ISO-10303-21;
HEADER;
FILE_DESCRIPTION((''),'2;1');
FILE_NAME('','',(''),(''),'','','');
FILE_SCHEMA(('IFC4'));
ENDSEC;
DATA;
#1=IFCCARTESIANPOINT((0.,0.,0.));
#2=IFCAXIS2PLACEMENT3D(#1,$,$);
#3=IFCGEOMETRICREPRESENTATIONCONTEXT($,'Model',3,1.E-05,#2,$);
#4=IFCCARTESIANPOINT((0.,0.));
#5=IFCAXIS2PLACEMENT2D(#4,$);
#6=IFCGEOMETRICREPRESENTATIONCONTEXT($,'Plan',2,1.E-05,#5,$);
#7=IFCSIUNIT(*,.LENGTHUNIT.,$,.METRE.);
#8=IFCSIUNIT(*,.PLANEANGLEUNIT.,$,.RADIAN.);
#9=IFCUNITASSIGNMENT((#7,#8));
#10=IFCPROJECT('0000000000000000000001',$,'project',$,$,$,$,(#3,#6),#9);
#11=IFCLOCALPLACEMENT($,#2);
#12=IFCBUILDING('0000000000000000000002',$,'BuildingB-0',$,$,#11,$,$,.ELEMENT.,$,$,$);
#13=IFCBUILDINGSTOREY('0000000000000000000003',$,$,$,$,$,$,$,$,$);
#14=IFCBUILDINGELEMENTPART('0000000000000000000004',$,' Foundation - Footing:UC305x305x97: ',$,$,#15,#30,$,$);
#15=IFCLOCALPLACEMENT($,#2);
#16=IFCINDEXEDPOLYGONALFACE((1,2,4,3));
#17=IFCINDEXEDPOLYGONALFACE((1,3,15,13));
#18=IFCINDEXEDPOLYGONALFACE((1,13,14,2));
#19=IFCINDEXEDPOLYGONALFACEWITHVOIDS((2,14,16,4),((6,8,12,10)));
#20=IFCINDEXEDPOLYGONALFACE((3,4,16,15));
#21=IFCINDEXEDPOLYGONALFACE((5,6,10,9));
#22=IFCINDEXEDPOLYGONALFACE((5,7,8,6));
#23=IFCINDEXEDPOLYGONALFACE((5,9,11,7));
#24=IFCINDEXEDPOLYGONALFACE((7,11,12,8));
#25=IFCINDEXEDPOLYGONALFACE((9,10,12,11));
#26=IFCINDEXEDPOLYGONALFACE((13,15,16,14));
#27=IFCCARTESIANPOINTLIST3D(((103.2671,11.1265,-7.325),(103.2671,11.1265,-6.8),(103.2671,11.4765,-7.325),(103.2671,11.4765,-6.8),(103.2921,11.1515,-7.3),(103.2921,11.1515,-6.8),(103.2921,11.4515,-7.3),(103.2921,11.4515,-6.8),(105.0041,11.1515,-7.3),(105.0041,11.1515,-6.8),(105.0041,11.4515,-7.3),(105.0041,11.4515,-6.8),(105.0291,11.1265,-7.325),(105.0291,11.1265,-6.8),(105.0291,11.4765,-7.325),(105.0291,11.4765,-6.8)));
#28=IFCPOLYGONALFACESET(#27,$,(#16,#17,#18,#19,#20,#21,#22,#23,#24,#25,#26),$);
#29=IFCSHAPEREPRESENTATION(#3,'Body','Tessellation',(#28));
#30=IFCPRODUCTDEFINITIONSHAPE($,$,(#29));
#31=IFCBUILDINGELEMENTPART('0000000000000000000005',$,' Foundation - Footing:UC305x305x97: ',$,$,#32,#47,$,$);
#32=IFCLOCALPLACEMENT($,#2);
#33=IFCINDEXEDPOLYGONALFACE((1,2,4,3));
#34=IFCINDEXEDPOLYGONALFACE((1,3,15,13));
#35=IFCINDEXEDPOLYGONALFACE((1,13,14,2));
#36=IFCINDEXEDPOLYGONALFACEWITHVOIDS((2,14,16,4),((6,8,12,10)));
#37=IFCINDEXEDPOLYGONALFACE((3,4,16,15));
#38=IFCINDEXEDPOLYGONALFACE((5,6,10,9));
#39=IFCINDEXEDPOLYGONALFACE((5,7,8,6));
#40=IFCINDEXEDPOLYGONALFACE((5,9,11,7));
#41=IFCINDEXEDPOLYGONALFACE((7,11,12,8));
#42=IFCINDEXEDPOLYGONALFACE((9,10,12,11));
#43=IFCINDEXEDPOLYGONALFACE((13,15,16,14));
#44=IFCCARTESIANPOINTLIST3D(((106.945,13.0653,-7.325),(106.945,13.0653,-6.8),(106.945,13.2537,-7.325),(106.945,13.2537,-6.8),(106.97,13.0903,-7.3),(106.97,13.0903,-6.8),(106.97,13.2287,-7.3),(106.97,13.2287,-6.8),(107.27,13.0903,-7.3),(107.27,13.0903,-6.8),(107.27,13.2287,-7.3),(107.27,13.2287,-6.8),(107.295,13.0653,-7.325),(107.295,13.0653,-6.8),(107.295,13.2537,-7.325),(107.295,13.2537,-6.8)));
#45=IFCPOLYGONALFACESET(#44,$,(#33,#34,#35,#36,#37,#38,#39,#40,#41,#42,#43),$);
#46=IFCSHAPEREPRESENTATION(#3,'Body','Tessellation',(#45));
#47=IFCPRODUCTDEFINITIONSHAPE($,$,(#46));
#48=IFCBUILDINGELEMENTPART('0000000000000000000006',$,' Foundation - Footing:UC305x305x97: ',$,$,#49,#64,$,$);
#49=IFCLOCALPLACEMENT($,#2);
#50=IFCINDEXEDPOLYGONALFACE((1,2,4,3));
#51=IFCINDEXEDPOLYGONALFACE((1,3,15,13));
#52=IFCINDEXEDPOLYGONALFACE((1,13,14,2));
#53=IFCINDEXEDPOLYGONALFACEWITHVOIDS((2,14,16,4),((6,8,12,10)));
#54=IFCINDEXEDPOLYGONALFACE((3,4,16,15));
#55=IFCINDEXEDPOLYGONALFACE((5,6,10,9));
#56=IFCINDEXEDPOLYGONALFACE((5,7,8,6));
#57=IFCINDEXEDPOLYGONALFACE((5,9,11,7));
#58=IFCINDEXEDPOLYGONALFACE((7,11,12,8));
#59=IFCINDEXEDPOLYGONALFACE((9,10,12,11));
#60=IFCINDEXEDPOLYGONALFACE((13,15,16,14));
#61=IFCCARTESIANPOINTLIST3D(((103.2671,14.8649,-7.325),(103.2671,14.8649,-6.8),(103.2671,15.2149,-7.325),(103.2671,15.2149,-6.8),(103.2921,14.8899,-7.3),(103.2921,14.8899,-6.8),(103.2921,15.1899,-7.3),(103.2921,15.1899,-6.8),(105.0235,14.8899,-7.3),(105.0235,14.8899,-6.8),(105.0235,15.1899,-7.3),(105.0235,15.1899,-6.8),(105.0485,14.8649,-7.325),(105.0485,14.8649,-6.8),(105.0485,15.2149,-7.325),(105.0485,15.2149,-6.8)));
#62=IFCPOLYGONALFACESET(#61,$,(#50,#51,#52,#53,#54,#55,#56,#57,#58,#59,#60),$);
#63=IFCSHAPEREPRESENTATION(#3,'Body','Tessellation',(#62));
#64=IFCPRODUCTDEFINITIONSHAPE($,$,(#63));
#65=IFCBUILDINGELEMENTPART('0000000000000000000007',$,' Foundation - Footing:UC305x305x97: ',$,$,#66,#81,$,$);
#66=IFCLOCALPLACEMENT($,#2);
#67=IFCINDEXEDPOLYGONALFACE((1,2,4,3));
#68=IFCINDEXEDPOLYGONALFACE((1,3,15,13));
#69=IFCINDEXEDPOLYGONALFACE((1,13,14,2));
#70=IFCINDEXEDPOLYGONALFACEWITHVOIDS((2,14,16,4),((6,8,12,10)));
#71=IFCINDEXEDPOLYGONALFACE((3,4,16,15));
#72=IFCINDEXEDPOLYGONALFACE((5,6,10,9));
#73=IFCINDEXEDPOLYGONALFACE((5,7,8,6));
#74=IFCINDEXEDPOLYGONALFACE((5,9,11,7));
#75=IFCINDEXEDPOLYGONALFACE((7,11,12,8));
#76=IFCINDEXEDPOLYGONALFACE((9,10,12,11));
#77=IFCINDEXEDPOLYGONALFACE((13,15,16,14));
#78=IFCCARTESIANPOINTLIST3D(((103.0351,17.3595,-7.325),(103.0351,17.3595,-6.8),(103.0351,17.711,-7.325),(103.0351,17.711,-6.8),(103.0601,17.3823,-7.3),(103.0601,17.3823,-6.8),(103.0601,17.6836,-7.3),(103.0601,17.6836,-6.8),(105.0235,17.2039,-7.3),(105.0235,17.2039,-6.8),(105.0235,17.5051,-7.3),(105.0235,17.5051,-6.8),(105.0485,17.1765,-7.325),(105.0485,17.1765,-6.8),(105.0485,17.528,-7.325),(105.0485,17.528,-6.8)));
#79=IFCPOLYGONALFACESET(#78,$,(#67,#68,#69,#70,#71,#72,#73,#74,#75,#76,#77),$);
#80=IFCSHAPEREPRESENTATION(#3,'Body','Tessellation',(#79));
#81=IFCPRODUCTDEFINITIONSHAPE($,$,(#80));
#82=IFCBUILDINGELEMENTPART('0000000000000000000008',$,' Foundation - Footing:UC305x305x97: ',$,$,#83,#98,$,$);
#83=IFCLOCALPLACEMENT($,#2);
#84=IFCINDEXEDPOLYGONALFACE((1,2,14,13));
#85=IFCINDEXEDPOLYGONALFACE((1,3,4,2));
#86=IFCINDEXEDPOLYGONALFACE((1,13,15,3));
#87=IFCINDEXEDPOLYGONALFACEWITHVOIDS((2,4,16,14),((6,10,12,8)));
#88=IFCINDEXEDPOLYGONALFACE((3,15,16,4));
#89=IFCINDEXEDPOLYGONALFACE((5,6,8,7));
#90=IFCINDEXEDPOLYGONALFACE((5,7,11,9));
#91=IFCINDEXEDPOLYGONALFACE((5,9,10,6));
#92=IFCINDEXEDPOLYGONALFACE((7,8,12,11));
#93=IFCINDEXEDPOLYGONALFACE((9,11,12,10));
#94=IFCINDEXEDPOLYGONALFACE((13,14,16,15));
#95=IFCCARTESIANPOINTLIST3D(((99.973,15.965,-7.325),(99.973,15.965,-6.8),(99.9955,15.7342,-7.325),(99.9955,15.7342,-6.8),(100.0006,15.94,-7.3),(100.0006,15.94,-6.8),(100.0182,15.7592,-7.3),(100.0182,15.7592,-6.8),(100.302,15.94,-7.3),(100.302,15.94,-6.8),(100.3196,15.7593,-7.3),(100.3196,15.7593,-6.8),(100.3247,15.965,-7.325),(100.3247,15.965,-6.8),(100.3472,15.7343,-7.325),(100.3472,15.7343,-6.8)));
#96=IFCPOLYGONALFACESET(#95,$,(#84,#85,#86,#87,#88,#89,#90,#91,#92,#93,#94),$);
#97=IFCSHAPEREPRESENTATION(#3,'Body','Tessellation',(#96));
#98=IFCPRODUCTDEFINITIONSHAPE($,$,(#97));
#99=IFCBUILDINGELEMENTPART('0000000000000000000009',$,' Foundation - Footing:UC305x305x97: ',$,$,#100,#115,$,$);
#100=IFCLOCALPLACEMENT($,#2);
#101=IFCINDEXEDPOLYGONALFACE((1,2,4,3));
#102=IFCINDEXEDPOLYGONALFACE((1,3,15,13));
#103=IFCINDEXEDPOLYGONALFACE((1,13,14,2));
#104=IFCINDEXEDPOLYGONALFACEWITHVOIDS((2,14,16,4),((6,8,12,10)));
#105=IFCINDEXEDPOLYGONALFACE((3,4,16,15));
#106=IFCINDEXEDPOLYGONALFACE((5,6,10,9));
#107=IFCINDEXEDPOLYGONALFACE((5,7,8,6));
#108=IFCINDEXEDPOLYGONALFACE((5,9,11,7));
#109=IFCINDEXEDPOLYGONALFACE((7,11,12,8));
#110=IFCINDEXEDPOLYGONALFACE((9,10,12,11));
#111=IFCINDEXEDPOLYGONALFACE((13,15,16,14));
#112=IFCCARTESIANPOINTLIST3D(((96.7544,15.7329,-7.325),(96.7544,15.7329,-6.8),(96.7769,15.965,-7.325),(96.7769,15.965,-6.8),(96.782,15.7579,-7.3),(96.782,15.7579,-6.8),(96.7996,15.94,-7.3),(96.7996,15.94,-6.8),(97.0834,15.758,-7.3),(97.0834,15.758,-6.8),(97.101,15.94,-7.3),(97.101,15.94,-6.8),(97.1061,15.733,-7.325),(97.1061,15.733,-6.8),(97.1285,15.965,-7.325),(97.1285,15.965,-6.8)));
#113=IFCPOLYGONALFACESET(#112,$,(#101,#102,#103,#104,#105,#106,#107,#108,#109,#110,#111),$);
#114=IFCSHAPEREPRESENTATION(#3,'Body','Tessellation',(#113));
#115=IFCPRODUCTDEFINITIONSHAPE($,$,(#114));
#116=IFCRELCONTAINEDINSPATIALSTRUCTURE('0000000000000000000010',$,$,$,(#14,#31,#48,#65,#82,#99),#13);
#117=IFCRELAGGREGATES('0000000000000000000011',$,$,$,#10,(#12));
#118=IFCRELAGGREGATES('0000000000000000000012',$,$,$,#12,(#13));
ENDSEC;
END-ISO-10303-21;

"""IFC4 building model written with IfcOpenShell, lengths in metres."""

from ifc_helpers import new_model, si_unit, origin, origin_2d, place, context, project, spatial, polyline, outline, extrude, element, save


model = new_model("IFC4")

# Units and contexts
model_context = context("Model", 3, precision=1e-05, world=origin())
plan_context = context("Plan", 2, precision=1e-05, world=origin_2d())
ifc_project = project(units=[si_unit("LENGTHUNIT", "METRE"), si_unit("PLANEANGLEUNIT", "RADIAN")], contexts=[model_context, plan_context])

# Building, storey
building_placement = place(None, origin())
building = spatial("IfcBuilding", under=ifc_project, at=building_placement, Name="BuildingB-0", CompositionType="ELEMENT")
storey = spatial("IfcBuildingStorey", under=building)

# Building element parts, openings
building_element_part_1 = element("IfcBuildingElementPart", 1, inside=storey, Name=" Foundation - Footing:UC305x305x97: ", context=model_context, shape_type="SweptSolid", body=[
    extrude(outline(polyline([(105.0291, 11.1265, -7.325), (105.0291, 11.4765, -7.325), (103.2671, 11.4765, -7.325), (103.2671, 11.1265, -7.325), (105.0291, 11.1265, -7.325)])), None, (0.0, 0.0, 1.0), 0.525),
])
element("IfcOpeningElement", 2, inside=storey, cuts=building_element_part_1, context=model_context, shape_type="SweptSolid", body=[
    extrude(outline(polyline([(105.0041, 11.1515, -7.3), (105.0041, 11.4515, -7.3), (103.2921, 11.4515, -7.3), (103.2921, 11.1515, -7.3), (105.0041, 11.1515, -7.3)])), None, (0.0, 0.0, 1.0), 0.5),
])
building_element_part_2 = element("IfcBuildingElementPart", 3, inside=storey, Name=" Foundation - Footing:UC305x305x97: ", context=model_context, shape_type="SweptSolid", body=[
    extrude(outline(polyline([(107.295, 13.0653, -7.325), (107.295, 13.2537, -7.325), (106.945, 13.2537, -7.325), (106.945, 13.0653, -7.325), (107.295, 13.0653, -7.325)])), None, (0.0, 0.0, 1.0), 0.525),
])
element("IfcOpeningElement", 4, inside=storey, cuts=building_element_part_2, context=model_context, shape_type="SweptSolid", body=[
    extrude(outline(polyline([(107.27, 13.0903, -7.3), (107.27, 13.2287, -7.3), (106.97, 13.2287, -7.3), (106.97, 13.0903, -7.3), (107.27, 13.0903, -7.3)])), None, (0.0, 0.0, 1.0), 0.5),
])
building_element_part_3 = element("IfcBuildingElementPart", 5, inside=storey, Name=" Foundation - Footing:UC305x305x97: ", context=model_context, shape_type="SweptSolid", body=[
    extrude(outline(polyline([(105.0485, 14.8649, -7.325), (105.0485, 15.2149, -7.325), (103.2671, 15.2149, -7.325), (103.2671, 14.8649, -7.325), (105.0485, 14.8649, -7.325)])), None, (0.0, 0.0, 1.0), 0.525),
])
element("IfcOpeningElement", 6, inside=storey, cuts=building_element_part_3, context=model_context, shape_type="SweptSolid", body=[
    extrude(outline(polyline([(105.0235, 14.8899, -7.3), (105.0235, 15.1899, -7.3), (103.2921, 15.1899, -7.3), (103.2921, 14.8899, -7.3), (105.0235, 14.8899, -7.3)])), None, (0.0, 0.0, 1.0), 0.5),
])
building_element_part_4 = element("IfcBuildingElementPart", 7, inside=storey, Name=" Foundation - Footing:UC305x305x97: ", context=model_context, shape_type="SweptSolid", body=[
    extrude(outline(polyline([(105.0485, 17.1765, -7.325), (105.0485, 17.528, -7.325), (103.0351, 17.711, -7.325), (103.0351, 17.3595, -7.325), (105.0485, 17.1765, -7.325)])), None, (0.0, 0.0, 1.0), 0.525),
])
element("IfcOpeningElement", 8, inside=storey, cuts=building_element_part_4, context=model_context, shape_type="SweptSolid", body=[
    extrude(outline(polyline([(105.0235, 17.2039, -7.3), (105.0235, 17.5051, -7.3), (103.0601, 17.6836, -7.3), (103.0601, 17.3823, -7.3), (105.0235, 17.2039, -7.3)])), None, (0.0, 0.0, 1.0), 0.5),
])
building_element_part_5 = element("IfcBuildingElementPart", 9, inside=storey, Name=" Foundation - Footing:UC305x305x97: ", context=model_context, shape_type="SweptSolid", body=[
    extrude(outline(polyline([(100.3472, 15.7343, -7.325), (100.3247, 15.965, -7.325), (99.973, 15.965, -7.325), (99.9955, 15.7342, -7.325), (100.3472, 15.7343, -7.325)])), None, (0.0, 0.0, 1.0), 0.525),
])
element("IfcOpeningElement", 10, inside=storey, cuts=building_element_part_5, context=model_context, shape_type="SweptSolid", body=[
    extrude(outline(polyline([(100.3196, 15.7593, -7.3), (100.302, 15.94, -7.3), (100.0006, 15.94, -7.3), (100.0182, 15.7592, -7.3), (100.3196, 15.7593, -7.3)])), None, (0.0, 0.0, 1.0), 0.5),
])
building_element_part_6 = element("IfcBuildingElementPart", 11, inside=storey, Name=" Foundation - Footing:UC305x305x97: ", context=model_context, shape_type="SweptSolid", body=[
    extrude(outline(polyline([(97.1061, 15.733, -7.325), (97.1285, 15.965, -7.325), (96.7769, 15.965, -7.325), (96.7544, 15.7329, -7.325), (97.1061, 15.733, -7.325)])), None, (0.0, 0.0, 1.0), 0.525),
])
element("IfcOpeningElement", 12, inside=storey, cuts=building_element_part_6, context=model_context, shape_type="SweptSolid", body=[
    extrude(outline(polyline([(97.0834, 15.758, -7.3), (97.101, 15.94, -7.3), (96.7996, 15.94, -7.3), (96.782, 15.7579, -7.3), (97.0834, 15.758, -7.3)])), None, (0.0, 0.0, 1.0), 0.5),
])

save(model, "model.ifc")
